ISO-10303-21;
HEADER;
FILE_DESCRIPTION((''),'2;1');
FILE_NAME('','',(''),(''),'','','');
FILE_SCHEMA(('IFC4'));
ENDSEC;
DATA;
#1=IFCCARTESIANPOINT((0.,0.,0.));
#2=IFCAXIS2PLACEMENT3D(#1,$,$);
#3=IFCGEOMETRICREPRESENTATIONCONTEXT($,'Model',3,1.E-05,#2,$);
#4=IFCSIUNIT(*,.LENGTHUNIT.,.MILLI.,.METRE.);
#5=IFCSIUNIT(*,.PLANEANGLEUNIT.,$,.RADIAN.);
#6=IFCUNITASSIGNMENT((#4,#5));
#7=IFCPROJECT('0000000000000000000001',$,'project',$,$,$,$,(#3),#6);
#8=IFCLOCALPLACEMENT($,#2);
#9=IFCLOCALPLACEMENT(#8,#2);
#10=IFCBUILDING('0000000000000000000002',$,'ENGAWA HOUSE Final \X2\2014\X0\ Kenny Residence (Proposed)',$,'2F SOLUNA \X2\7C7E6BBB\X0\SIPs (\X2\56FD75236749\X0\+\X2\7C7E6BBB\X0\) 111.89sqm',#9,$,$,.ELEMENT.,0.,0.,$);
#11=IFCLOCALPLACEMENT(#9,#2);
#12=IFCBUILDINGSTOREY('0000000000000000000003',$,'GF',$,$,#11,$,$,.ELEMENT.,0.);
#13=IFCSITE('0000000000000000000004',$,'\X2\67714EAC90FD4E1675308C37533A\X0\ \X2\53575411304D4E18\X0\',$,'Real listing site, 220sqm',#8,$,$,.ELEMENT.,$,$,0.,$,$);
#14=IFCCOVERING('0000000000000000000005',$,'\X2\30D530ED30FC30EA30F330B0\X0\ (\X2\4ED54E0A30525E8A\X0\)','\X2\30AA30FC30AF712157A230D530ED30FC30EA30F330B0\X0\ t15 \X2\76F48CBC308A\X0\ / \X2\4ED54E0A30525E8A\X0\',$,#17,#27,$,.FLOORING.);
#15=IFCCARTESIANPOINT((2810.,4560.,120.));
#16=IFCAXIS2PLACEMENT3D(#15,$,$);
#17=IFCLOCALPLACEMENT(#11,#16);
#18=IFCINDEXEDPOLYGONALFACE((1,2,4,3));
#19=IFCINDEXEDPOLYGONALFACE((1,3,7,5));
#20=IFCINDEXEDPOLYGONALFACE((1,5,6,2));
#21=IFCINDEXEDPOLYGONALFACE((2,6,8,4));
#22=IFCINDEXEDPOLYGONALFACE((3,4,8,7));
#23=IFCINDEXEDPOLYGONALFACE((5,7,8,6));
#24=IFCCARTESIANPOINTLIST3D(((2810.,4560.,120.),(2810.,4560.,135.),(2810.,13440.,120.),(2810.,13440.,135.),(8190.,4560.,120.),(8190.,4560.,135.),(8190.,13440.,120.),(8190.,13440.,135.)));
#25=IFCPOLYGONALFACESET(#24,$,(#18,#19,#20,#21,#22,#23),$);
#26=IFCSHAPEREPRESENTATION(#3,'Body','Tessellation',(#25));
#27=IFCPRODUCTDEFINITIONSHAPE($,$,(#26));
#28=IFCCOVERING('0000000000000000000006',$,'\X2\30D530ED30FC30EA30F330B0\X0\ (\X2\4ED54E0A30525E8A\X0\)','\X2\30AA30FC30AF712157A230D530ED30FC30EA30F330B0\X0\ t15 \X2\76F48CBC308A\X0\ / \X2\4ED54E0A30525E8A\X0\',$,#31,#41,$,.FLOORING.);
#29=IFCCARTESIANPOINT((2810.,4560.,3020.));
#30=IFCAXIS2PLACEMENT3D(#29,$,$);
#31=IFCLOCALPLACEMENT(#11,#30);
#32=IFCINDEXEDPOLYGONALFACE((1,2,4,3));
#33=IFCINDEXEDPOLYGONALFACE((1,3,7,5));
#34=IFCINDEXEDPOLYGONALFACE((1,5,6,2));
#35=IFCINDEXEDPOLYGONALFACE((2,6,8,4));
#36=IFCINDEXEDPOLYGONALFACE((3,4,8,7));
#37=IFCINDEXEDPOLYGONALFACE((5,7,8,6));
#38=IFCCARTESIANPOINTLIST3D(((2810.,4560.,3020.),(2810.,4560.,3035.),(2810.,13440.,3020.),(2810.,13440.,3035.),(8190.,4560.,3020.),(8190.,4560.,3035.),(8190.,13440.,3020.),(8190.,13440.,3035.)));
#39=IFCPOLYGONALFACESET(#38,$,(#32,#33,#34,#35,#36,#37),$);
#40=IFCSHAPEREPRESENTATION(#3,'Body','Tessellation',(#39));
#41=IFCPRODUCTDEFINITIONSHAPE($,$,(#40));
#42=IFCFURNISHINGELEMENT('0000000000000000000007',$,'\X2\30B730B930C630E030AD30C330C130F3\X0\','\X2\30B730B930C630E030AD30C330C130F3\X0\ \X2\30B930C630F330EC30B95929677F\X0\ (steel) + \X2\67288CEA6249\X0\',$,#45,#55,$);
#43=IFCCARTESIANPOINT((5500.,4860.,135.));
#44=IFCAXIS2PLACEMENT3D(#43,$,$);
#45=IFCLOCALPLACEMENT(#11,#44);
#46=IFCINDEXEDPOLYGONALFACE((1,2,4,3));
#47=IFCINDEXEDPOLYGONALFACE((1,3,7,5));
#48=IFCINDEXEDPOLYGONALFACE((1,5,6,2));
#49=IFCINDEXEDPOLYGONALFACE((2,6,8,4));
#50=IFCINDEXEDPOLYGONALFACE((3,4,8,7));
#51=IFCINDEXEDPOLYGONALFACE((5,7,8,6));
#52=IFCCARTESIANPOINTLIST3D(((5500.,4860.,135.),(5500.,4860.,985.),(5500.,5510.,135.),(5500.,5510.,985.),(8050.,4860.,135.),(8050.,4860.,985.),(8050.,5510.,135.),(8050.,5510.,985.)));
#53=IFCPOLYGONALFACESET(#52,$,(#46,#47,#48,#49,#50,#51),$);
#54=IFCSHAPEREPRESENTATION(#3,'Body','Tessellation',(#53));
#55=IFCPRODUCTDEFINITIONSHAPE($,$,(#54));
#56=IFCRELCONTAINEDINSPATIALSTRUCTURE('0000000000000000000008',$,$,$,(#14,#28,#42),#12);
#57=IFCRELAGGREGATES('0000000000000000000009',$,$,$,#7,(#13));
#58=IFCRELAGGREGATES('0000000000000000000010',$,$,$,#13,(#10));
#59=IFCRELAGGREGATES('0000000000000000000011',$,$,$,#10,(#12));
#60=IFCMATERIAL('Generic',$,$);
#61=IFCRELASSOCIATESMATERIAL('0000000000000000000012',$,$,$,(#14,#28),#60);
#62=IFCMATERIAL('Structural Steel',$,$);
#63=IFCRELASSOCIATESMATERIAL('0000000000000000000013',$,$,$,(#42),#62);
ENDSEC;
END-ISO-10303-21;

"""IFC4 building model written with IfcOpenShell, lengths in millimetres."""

from ifc_helpers import new_model, si_unit, frame, frame_2d, origin, place, context, project, spatial, rectangle, extrude, material, element, save


model = new_model("IFC4")

# Units and contexts
model_context = context("Model", 3, precision=1e-05, world=origin())
ifc_project = project(units=[si_unit("LENGTHUNIT", "METRE", prefix="MILLI"), si_unit("PLANEANGLEUNIT", "RADIAN")], contexts=[model_context])

# Site, building, storey
site_placement = place(None, origin())
site = spatial("IfcSite", under=ifc_project, at=site_placement, Name="東京都世田谷区 南向き丘", ObjectType="Real listing site, 220sqm", CompositionType="ELEMENT", RefElevation=0.0)
building_placement = place(site_placement, origin())
building = spatial("IfcBuilding", under=site, at=building_placement, Name="ENGAWA HOUSE Final — Kenny Residence (Proposed)", ObjectType="2F SOLUNA 籾殻SIPs (国産杉+籾殻) 111.89sqm", CompositionType="ELEMENT", ElevationOfRefHeight=0.0, ElevationOfTerrain=0.0)
storey_placement = place(building_placement, origin())
storey = spatial("IfcBuildingStorey", under=building, at=storey_placement, Name="GF", CompositionType="ELEMENT", Elevation=0.0)

# Shared definitions
ifc_material_1 = material(Name="Generic")

# Shared definitions
ifc_material_2 = material(Name="Structural Steel")

# Coverings
covering_1_placement = place(storey_placement, frame((2810.0, 4560.0, 120.0)))
element("IfcCovering", 1, at=covering_1_placement, inside=storey, material=ifc_material_1, Name="フローリング (仕上げ床)", Description="オーク無垢フローリング t15 直貼り / 仕上げ床", PredefinedType="FLOORING", context=model_context, shape_type="SweptSolid", body=[
    extrude(rectangle(XDim=5380.0, YDim=8880.0, at=frame_2d((2690.0, 4440.0))), frame((2810.0, 4560.0, 120.0)), (0.0, 0.0, 1.0), 15.0),
])
covering_2_placement = place(storey_placement, frame((2810.0, 4560.0, 3020.0)))
element("IfcCovering", 2, at=covering_2_placement, inside=storey, material=ifc_material_1, Name="フローリング (仕上げ床)", Description="オーク無垢フローリング t15 直貼り / 仕上げ床", PredefinedType="FLOORING", context=model_context, shape_type="SweptSolid", body=[
    extrude(rectangle(XDim=5380.0, YDim=8880.0, at=frame_2d((2690.0, 4440.0))), frame((2810.0, 4560.0, 3020.0)), (0.0, 0.0, 1.0), 15.0),
])

# Furnishing element
furnishing_placement = place(storey_placement, frame((5500.0, 4860.0, 135.0)))
element("IfcFurnishingElement", 3, at=furnishing_placement, inside=storey, material=ifc_material_2, Name="システムキッチン", Description="システムキッチン ステンレス天板 (steel) + 木質扉", context=model_context, shape_type="SweptSolid", body=[
    extrude(rectangle(XDim=2550.0, YDim=650.0, at=frame_2d((1275.0, 325.0))), frame((5500.0, 4860.0, 135.0)), (0.0, 0.0, 1.0), 850.0),
])

save(model, "model.ifc")
